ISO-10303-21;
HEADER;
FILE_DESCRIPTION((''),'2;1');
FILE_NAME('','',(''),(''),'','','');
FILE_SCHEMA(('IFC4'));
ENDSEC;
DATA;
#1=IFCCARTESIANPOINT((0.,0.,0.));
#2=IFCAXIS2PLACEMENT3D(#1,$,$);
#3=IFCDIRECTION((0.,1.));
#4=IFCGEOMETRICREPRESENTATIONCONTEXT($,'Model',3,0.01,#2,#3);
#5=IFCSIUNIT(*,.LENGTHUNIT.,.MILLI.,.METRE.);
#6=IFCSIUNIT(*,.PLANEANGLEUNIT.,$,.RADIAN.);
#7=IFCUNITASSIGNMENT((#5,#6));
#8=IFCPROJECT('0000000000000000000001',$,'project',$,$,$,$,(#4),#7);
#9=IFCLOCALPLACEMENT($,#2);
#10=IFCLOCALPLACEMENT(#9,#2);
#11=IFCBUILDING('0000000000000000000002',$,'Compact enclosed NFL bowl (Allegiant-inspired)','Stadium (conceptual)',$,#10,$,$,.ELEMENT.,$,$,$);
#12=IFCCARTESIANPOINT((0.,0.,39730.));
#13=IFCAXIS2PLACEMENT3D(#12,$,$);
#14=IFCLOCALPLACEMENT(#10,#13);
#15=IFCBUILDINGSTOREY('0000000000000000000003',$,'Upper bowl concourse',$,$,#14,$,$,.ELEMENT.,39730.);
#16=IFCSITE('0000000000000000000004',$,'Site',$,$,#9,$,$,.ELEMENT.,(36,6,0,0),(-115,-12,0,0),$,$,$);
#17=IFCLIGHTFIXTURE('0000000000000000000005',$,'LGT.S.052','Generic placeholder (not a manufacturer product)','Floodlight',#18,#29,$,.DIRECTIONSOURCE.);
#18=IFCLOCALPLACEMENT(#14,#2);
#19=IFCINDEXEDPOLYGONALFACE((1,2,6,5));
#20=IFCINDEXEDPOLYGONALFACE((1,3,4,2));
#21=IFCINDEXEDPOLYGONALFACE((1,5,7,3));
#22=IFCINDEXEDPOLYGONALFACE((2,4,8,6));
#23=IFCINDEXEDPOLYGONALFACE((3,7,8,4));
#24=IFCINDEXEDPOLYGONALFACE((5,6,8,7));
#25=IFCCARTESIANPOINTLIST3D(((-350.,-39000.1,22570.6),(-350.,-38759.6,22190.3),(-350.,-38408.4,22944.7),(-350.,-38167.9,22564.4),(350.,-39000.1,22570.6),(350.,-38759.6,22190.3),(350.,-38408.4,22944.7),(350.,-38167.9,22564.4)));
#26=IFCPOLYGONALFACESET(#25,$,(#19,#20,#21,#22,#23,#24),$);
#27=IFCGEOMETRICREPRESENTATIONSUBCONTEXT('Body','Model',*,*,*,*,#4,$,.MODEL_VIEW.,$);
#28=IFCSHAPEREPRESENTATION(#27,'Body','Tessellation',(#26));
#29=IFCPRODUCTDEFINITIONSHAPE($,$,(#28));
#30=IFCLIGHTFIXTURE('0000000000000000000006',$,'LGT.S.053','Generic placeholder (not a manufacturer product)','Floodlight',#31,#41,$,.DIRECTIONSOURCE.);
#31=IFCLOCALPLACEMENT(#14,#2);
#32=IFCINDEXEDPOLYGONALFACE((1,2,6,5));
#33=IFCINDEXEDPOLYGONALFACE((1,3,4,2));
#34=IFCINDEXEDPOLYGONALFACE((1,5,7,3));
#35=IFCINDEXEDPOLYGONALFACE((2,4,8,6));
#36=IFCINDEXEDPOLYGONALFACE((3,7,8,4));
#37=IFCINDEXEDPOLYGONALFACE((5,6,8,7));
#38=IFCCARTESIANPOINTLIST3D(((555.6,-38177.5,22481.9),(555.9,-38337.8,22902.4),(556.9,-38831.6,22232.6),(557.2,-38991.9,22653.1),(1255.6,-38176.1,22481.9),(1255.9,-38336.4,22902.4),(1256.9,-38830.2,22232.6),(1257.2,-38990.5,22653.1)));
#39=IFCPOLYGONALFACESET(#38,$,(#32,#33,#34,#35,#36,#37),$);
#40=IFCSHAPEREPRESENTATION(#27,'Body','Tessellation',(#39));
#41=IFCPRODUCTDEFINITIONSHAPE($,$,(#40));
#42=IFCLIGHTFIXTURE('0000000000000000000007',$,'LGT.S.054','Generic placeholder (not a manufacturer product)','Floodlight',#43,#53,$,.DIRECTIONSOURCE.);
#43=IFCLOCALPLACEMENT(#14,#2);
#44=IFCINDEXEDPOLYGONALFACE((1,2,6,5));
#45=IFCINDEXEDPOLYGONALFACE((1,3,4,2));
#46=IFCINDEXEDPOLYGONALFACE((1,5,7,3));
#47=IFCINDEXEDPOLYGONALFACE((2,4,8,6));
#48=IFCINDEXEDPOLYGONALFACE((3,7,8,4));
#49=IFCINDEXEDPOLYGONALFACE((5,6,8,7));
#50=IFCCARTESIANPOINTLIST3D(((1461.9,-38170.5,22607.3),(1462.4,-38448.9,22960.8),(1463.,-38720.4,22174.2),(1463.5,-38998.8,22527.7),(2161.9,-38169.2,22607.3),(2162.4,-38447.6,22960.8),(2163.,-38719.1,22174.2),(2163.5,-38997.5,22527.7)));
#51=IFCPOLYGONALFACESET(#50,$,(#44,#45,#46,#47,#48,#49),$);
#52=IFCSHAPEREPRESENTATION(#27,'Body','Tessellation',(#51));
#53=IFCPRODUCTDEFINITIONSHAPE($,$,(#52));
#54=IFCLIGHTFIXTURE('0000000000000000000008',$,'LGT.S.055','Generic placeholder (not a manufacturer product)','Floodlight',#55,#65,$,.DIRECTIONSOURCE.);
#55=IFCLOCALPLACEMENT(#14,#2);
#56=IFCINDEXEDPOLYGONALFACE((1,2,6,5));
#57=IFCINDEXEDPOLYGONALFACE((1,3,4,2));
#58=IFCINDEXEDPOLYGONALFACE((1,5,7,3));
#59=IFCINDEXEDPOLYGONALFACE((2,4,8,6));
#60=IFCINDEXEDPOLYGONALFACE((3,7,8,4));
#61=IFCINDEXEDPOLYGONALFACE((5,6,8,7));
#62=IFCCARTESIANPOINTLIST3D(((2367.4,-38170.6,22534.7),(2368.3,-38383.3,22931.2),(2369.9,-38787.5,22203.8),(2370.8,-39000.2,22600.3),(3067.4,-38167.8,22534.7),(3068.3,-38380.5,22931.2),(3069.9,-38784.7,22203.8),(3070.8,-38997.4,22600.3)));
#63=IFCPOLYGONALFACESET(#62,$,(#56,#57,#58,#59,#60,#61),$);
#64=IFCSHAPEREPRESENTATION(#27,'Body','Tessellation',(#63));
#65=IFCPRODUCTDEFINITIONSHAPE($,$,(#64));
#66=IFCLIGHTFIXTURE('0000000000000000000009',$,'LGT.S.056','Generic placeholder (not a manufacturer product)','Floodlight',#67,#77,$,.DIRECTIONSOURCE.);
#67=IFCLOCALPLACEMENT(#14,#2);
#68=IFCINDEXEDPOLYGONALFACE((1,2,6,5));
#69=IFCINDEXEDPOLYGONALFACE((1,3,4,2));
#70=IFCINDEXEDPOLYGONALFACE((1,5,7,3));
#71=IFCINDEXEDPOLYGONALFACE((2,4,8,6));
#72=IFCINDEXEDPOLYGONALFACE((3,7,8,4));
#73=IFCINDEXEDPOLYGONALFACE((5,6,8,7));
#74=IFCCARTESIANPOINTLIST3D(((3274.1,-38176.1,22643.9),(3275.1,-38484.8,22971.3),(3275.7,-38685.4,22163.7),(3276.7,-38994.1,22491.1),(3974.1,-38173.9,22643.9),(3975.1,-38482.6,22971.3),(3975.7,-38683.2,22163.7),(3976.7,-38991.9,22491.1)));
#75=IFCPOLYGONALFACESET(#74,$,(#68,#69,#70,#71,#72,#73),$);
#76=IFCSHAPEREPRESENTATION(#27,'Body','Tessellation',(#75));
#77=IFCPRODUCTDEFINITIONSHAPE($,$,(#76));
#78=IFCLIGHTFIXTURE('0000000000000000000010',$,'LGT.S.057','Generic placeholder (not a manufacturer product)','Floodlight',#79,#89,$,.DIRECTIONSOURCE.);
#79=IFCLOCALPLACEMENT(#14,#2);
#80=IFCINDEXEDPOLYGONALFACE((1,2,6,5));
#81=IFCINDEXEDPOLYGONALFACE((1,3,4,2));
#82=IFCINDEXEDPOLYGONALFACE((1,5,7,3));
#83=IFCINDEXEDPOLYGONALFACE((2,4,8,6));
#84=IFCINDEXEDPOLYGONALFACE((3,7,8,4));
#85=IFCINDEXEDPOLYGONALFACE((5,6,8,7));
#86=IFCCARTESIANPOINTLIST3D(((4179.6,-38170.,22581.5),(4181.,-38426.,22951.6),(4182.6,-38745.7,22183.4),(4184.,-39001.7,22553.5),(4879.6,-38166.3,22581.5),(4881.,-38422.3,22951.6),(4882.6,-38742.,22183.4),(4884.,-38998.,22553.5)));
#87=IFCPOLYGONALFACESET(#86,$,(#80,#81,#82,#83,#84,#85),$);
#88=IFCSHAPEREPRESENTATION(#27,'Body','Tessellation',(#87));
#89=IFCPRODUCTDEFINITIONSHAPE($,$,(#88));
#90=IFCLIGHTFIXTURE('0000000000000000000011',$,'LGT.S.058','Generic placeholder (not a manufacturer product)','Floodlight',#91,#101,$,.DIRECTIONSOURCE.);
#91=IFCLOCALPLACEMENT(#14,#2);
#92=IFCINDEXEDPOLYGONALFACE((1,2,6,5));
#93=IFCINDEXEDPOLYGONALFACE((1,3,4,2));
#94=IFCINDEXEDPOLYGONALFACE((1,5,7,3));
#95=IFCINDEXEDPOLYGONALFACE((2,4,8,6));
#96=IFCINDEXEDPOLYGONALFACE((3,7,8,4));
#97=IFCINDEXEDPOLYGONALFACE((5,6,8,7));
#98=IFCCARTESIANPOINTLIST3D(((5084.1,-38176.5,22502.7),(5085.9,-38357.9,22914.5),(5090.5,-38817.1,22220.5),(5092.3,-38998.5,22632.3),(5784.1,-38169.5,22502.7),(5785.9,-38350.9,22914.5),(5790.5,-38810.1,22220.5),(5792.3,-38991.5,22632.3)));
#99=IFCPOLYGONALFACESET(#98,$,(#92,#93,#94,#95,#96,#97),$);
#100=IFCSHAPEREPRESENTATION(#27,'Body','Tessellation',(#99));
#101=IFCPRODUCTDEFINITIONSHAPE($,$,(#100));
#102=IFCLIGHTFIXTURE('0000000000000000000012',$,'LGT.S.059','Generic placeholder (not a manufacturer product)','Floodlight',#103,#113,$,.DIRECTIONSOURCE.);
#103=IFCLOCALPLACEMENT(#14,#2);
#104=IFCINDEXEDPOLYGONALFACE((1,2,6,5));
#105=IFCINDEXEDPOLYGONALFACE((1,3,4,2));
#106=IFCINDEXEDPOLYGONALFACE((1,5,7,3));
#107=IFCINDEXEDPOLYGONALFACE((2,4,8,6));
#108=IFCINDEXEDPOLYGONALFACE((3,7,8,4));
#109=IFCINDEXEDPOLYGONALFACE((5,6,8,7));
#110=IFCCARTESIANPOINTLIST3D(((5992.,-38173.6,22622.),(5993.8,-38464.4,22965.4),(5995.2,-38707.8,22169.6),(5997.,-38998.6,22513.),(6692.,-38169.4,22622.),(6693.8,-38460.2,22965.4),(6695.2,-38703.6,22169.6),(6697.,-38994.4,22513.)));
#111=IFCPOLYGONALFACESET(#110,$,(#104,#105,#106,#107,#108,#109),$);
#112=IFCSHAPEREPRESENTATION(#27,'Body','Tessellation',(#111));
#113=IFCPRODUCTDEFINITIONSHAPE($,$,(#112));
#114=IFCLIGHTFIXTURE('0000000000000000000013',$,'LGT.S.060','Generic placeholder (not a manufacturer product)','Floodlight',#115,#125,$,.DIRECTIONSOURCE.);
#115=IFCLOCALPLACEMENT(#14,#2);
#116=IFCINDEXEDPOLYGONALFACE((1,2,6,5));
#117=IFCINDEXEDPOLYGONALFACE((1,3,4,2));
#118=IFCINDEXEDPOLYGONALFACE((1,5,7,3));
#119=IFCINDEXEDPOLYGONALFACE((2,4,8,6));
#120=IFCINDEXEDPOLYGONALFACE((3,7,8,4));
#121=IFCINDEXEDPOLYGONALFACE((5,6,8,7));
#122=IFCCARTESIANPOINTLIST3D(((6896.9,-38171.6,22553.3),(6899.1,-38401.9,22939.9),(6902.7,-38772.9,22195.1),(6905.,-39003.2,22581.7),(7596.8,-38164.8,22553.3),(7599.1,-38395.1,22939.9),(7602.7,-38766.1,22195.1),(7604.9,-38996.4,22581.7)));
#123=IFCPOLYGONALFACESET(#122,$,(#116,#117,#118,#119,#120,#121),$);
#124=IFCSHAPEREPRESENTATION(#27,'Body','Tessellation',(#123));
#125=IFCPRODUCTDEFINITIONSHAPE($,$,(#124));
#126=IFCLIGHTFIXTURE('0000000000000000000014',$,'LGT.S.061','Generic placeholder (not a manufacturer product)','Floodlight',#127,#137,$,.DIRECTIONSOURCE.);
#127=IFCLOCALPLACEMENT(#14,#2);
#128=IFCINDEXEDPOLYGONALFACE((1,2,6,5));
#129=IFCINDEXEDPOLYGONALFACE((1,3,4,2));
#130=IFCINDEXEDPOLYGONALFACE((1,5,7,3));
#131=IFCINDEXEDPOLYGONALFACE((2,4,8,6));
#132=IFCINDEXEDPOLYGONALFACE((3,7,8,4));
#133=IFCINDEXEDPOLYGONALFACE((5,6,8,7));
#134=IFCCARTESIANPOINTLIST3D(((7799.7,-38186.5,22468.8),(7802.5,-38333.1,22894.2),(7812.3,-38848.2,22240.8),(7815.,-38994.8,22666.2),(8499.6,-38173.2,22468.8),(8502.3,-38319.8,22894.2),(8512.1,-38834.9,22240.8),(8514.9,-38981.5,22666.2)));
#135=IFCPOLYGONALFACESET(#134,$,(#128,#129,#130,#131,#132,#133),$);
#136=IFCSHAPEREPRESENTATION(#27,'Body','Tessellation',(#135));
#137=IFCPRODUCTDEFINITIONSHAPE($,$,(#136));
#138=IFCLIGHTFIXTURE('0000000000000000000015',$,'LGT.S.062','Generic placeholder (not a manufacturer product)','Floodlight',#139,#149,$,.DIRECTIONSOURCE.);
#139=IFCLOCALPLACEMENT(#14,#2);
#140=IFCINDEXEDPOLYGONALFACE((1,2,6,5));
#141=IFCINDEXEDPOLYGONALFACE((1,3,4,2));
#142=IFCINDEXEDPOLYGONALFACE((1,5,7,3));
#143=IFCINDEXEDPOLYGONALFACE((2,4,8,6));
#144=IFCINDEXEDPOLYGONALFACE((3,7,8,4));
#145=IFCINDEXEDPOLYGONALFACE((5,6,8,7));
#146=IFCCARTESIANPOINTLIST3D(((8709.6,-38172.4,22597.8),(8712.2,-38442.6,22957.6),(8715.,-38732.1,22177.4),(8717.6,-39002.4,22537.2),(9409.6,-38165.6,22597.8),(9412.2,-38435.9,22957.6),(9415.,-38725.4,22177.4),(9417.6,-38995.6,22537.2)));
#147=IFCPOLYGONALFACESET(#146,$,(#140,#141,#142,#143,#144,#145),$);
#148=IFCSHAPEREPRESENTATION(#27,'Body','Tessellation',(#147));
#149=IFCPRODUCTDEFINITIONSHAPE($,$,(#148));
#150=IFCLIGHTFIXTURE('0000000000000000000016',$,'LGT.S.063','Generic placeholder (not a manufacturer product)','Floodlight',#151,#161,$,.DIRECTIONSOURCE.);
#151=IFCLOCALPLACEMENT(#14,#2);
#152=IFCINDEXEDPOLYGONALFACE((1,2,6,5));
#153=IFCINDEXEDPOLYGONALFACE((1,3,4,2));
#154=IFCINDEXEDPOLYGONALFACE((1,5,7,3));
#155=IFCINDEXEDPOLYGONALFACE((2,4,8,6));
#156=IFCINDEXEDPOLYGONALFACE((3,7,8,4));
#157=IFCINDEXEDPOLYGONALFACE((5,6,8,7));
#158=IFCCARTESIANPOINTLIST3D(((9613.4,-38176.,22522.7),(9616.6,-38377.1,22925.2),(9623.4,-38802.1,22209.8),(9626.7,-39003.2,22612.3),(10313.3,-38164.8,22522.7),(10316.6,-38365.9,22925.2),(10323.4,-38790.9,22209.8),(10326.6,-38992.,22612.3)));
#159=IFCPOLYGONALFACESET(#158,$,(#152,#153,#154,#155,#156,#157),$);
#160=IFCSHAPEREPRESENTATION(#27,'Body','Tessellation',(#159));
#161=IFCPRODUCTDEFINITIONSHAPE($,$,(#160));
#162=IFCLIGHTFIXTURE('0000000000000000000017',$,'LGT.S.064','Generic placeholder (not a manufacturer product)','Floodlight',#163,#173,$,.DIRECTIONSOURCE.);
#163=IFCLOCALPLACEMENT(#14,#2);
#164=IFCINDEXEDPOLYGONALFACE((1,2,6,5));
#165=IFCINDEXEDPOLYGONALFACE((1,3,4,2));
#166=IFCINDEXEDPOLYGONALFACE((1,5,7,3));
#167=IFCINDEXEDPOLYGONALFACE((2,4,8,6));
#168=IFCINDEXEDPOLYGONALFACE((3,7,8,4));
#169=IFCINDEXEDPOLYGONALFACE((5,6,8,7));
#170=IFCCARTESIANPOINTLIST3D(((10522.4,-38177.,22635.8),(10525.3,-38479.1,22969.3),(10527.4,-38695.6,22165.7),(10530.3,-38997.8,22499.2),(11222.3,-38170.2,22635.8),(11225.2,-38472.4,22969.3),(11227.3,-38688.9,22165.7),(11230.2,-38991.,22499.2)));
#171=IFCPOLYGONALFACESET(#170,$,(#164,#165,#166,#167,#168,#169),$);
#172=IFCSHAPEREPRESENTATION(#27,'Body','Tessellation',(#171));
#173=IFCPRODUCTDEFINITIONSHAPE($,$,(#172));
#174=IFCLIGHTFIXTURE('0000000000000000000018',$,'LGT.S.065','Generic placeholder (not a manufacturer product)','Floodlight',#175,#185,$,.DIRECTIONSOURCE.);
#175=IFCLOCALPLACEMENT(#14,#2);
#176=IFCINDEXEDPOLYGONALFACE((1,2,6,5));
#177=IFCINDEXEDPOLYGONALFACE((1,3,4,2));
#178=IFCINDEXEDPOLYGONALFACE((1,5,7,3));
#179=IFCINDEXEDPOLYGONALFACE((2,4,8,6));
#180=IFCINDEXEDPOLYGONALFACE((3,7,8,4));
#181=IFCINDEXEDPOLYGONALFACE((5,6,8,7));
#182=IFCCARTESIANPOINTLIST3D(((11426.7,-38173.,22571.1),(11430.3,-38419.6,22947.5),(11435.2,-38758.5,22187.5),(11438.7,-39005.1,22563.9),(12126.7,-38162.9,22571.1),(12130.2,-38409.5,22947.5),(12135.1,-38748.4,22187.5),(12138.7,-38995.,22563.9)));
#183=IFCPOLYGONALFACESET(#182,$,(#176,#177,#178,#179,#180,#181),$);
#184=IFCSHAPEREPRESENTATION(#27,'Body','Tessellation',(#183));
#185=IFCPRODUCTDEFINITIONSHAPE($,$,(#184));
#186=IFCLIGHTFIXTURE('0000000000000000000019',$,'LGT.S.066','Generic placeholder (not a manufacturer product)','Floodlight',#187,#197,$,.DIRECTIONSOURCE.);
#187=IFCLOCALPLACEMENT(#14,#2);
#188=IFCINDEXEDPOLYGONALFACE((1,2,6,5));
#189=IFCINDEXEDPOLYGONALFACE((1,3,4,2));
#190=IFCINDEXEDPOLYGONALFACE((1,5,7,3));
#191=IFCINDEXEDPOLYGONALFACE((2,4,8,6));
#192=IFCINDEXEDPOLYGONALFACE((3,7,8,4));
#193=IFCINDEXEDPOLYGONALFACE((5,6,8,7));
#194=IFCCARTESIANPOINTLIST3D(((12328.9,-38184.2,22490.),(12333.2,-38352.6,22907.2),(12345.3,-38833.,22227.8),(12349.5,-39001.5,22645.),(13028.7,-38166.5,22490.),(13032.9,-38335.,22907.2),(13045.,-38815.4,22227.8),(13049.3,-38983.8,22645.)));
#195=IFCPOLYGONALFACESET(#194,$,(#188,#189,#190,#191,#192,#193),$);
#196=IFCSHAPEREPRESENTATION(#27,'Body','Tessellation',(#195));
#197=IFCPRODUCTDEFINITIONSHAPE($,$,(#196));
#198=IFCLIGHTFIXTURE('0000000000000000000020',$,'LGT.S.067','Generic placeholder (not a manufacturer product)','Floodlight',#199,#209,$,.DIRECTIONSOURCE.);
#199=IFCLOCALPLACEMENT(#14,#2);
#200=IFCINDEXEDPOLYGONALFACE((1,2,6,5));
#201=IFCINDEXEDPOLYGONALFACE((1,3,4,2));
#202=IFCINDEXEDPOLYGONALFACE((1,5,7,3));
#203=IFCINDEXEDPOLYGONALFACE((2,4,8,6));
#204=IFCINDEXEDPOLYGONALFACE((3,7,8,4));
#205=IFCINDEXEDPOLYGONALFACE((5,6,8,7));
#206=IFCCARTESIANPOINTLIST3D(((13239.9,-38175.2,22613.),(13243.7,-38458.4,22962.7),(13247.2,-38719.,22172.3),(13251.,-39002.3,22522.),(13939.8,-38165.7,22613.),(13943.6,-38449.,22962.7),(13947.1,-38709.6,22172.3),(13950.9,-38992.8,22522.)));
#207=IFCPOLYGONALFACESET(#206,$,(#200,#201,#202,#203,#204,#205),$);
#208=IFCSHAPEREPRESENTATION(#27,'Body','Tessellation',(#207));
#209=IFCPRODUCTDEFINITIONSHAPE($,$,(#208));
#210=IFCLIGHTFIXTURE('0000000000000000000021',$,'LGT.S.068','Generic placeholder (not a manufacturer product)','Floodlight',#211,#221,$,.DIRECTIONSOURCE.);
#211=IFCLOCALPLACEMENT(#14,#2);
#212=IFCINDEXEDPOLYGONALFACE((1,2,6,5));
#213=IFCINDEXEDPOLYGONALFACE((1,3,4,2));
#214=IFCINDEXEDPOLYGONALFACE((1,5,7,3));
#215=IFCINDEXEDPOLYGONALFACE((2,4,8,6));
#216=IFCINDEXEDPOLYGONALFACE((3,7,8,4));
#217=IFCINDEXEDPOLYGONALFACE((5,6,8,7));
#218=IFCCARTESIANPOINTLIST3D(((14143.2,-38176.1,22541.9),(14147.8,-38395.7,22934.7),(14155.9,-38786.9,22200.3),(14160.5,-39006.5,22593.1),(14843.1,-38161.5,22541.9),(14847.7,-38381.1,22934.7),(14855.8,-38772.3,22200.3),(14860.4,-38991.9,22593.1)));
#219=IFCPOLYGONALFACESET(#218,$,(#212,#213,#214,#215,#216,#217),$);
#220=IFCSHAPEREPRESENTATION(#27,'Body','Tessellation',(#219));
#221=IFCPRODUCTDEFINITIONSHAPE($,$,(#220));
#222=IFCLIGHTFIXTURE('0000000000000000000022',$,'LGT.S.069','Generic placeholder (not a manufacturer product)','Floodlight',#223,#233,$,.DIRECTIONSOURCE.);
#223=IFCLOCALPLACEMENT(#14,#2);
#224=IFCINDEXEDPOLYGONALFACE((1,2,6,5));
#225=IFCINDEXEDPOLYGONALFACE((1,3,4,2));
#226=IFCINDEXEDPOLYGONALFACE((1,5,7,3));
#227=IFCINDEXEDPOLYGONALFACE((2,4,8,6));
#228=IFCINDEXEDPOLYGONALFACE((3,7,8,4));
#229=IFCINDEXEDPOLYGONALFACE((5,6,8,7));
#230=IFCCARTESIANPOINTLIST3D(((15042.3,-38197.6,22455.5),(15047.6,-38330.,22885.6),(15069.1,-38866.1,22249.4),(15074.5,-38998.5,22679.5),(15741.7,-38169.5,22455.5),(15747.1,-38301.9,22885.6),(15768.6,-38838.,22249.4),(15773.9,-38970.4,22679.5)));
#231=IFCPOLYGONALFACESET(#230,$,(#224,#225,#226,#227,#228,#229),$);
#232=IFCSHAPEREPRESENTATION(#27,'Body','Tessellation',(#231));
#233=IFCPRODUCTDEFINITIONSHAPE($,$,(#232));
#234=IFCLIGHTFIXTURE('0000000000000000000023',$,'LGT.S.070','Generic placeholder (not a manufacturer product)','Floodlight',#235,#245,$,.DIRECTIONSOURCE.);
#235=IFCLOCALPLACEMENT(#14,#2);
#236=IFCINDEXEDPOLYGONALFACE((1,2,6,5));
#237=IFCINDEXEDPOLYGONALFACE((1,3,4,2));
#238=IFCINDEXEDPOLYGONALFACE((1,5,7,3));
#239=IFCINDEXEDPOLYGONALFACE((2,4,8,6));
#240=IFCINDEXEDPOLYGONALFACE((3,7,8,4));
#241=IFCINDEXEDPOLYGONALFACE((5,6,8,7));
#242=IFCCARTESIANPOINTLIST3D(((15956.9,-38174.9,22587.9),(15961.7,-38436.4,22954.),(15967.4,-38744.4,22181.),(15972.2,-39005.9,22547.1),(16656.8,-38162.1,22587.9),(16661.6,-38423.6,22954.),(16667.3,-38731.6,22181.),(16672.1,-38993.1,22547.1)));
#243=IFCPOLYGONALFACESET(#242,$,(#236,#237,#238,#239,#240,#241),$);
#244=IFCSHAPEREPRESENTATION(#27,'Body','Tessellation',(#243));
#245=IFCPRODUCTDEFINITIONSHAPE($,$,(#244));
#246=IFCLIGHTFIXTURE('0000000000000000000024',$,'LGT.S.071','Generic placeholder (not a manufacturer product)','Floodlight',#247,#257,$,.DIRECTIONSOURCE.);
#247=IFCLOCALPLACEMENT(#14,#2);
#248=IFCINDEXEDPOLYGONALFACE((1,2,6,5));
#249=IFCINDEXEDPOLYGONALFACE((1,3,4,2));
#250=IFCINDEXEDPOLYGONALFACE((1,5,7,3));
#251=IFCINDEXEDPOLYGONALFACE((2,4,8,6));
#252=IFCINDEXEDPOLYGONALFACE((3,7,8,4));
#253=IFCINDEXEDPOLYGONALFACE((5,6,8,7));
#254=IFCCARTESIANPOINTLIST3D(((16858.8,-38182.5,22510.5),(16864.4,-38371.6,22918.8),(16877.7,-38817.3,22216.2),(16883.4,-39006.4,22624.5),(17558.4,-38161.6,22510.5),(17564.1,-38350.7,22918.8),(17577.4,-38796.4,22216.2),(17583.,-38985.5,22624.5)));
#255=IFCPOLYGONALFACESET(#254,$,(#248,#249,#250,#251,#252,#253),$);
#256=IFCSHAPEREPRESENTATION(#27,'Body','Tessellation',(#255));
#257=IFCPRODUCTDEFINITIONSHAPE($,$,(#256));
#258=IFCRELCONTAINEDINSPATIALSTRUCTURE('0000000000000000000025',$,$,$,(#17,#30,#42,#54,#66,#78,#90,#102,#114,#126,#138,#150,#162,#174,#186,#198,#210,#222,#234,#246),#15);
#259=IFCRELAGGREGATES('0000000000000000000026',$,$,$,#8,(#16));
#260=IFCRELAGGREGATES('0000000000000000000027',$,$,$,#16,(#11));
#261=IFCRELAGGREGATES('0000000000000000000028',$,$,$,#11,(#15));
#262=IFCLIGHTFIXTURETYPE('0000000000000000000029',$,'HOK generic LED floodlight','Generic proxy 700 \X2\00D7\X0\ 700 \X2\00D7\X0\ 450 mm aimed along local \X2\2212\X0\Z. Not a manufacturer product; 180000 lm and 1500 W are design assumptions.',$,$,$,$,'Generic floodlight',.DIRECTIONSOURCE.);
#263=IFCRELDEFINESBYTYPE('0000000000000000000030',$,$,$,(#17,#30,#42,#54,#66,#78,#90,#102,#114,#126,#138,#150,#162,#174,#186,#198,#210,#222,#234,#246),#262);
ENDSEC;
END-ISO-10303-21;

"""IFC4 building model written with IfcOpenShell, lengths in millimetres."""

from ifc_helpers import new_model, si_unit, direction, frame, origin, place, context, subcontext, project, spatial, rectangle, extrude, source, transform, mapped, type_object, type_shapes, element, save


model = new_model("IFC4")

# Units and contexts
model_context = context("Model", 3, precision=0.01, world=origin(), true_north=direction((0.0, 1.0)))
body_context = subcontext(model_context, "Body", "Model", "MODEL_VIEW")
ifc_project = project(units=[si_unit("LENGTHUNIT", "METRE", prefix="MILLI"), si_unit("PLANEANGLEUNIT", "RADIAN")], contexts=[model_context])

# Site, building, storey
site_placement = place(None, origin())
site = spatial("IfcSite", under=ifc_project, at=site_placement, Name="Site", CompositionType="ELEMENT", RefLatitude=(36, 6, 0, 0), RefLongitude=(-115, -12, 0, 0))
building_placement = place(site_placement, origin())
building = spatial("IfcBuilding", under=site, at=building_placement, Name="Compact enclosed NFL bowl (Allegiant-inspired)", Description="Stadium (conceptual)", CompositionType="ELEMENT")
storey_placement = place(building_placement, frame((0.0, 0.0, 39730.0)))
storey = spatial("IfcBuildingStorey", under=building, at=storey_placement, Name="Upper bowl concourse", CompositionType="ELEMENT", Elevation=39730.0)

# Light fixtures
light_fixture_type = type_object("IfcLightFixtureType", Name="HOK generic LED floodlight", Description="Generic proxy 700 × 700 × 450 mm aimed along local −Z. Not a manufacturer product; 180000 lm and 1500 W are design assumptions.", ElementType="Generic floodlight", PredefinedType="DIRECTIONSOURCE")
shared_shape = source(origin(), body_context, "Body", "SweptSolid", [
    extrude(rectangle(XDim=700.0, YDim=700.0), frame((0.0, 0.0, -225.0)), (0.0, 0.0, 1.0), 450.0),
])
type_shapes(light_fixture_type, [shared_shape])
for number, where, z_axis, x_axis, name in (
    (1, (0.0, -38584.0, 22567.5), (0.0, -0.534445, 0.845203), (1.0, 0.0, 0.0), "LGT.S.052"),
    (2, (906.4, -38584.0, 22567.5), (0.00068, -0.356162, 0.934424), (0.999998, 0.001909, 0.0), "LGT.S.053"),
    (3, (1812.7, -38584.0, 22567.5), (0.001143, -0.618717, 0.785613), (0.999998, 0.001847, 0.0), "LGT.S.054"),
    (4, (2719.1, -38584.0, 22567.5), (0.001923, -0.472682, 0.881231), (0.999992, 0.004069, 0.0), "LGT.S.055"),
    (5, (3625.4, -38584.0, 22567.5), (0.002117, -0.685986, 0.727612), (0.999995, 0.003086, 0.0), "LGT.S.056"),
    (6, (4531.8, -38584.0, 22567.5), (0.002991, -0.568825, 0.822453), (0.999986, 0.005259, 0.0), "LGT.S.057"),
    (7, (5438.2, -38584.0, 22567.5), (0.003994, -0.40308, 0.915156), (0.999951, 0.009909, 0.0), "LGT.S.058"),
    (8, (6344.5, -38584.0, 22567.5), (0.003886, -0.646248, 0.763118), (0.999982, 0.006013, 0.0), "LGT.S.059"),
    (9, (7250.9, -38584.0, 22567.5), (0.005, -0.511759, 0.859115), (0.999952, 0.009769, 0.0), "LGT.S.060"),
    (10, (8157.3, -38584.0, 22567.5), (0.00619, -0.325717, 0.945447), (0.999819, 0.019, 0.0), "LGT.S.061"),
    (11, (9063.6, -38584.0, 22567.5), (0.005817, -0.600457, 0.799636), (0.999953, 0.009687, 0.0), "LGT.S.062"),
    (12, (9970.0, -38584.0, 22567.5), (0.007158, -0.447018, 0.894496), (0.999872, 0.01601, 0.0), "LGT.S.063"),
    (13, (10876.3, -38584.0, 22567.5), (0.006469, -0.671463, 0.74101), (0.999954, 0.009633, 0.0), "LGT.S.064"),
    (14, (11782.7, -38584.0, 22567.5), (0.007911, -0.547894, 0.836511), (0.999896, 0.014437, 0.0), "LGT.S.065"),
    (15, (12689.1, -38584.0, 22567.5), (0.009443, -0.374413, 0.927214), (0.999682, 0.025213, 0.0), "LGT.S.066"),
    (16, (13595.4, -38584.0, 22567.5), (0.008478, -0.629496, 0.776957), (0.999909, 0.013467, 0.0), "LGT.S.067"),
    (17, (14501.8, -38584.0, 22567.5), (0.010159, -0.487938, 0.872819), (0.999783, 0.020815, 0.0), "LGT.S.068"),
    (18, (15408.1, -38584.0, 22567.5), (0.011818, -0.294217, 0.955666), (0.999194, 0.040136, 0.0), "LGT.S.069"),
    (19, (16314.5, -38584.0, 22567.5), (0.010655, -0.581196, 0.813694), (0.999832, 0.018329, 0.0), "LGT.S.070"),
    (20, (17220.9, -38584.0, 22567.5), (0.012541, -0.420191, 0.907349), (0.999555, 0.029832, 0.0), "LGT.S.071"),
):
    element("IfcLightFixture", number, at=place(storey_placement, frame(where, z_axis=z_axis, x_axis=x_axis)), inside=storey, type_object=light_fixture_type, Name=name, Description="Generic placeholder (not a manufacturer product)", ObjectType="Floodlight", PredefinedType="DIRECTIONSOURCE", context=body_context, shape_type="MappedRepresentation", body=[
        mapped(shared_shape, transform((0.0, 0.0, 0.0))),
    ])

save(model, "model.ifc")
